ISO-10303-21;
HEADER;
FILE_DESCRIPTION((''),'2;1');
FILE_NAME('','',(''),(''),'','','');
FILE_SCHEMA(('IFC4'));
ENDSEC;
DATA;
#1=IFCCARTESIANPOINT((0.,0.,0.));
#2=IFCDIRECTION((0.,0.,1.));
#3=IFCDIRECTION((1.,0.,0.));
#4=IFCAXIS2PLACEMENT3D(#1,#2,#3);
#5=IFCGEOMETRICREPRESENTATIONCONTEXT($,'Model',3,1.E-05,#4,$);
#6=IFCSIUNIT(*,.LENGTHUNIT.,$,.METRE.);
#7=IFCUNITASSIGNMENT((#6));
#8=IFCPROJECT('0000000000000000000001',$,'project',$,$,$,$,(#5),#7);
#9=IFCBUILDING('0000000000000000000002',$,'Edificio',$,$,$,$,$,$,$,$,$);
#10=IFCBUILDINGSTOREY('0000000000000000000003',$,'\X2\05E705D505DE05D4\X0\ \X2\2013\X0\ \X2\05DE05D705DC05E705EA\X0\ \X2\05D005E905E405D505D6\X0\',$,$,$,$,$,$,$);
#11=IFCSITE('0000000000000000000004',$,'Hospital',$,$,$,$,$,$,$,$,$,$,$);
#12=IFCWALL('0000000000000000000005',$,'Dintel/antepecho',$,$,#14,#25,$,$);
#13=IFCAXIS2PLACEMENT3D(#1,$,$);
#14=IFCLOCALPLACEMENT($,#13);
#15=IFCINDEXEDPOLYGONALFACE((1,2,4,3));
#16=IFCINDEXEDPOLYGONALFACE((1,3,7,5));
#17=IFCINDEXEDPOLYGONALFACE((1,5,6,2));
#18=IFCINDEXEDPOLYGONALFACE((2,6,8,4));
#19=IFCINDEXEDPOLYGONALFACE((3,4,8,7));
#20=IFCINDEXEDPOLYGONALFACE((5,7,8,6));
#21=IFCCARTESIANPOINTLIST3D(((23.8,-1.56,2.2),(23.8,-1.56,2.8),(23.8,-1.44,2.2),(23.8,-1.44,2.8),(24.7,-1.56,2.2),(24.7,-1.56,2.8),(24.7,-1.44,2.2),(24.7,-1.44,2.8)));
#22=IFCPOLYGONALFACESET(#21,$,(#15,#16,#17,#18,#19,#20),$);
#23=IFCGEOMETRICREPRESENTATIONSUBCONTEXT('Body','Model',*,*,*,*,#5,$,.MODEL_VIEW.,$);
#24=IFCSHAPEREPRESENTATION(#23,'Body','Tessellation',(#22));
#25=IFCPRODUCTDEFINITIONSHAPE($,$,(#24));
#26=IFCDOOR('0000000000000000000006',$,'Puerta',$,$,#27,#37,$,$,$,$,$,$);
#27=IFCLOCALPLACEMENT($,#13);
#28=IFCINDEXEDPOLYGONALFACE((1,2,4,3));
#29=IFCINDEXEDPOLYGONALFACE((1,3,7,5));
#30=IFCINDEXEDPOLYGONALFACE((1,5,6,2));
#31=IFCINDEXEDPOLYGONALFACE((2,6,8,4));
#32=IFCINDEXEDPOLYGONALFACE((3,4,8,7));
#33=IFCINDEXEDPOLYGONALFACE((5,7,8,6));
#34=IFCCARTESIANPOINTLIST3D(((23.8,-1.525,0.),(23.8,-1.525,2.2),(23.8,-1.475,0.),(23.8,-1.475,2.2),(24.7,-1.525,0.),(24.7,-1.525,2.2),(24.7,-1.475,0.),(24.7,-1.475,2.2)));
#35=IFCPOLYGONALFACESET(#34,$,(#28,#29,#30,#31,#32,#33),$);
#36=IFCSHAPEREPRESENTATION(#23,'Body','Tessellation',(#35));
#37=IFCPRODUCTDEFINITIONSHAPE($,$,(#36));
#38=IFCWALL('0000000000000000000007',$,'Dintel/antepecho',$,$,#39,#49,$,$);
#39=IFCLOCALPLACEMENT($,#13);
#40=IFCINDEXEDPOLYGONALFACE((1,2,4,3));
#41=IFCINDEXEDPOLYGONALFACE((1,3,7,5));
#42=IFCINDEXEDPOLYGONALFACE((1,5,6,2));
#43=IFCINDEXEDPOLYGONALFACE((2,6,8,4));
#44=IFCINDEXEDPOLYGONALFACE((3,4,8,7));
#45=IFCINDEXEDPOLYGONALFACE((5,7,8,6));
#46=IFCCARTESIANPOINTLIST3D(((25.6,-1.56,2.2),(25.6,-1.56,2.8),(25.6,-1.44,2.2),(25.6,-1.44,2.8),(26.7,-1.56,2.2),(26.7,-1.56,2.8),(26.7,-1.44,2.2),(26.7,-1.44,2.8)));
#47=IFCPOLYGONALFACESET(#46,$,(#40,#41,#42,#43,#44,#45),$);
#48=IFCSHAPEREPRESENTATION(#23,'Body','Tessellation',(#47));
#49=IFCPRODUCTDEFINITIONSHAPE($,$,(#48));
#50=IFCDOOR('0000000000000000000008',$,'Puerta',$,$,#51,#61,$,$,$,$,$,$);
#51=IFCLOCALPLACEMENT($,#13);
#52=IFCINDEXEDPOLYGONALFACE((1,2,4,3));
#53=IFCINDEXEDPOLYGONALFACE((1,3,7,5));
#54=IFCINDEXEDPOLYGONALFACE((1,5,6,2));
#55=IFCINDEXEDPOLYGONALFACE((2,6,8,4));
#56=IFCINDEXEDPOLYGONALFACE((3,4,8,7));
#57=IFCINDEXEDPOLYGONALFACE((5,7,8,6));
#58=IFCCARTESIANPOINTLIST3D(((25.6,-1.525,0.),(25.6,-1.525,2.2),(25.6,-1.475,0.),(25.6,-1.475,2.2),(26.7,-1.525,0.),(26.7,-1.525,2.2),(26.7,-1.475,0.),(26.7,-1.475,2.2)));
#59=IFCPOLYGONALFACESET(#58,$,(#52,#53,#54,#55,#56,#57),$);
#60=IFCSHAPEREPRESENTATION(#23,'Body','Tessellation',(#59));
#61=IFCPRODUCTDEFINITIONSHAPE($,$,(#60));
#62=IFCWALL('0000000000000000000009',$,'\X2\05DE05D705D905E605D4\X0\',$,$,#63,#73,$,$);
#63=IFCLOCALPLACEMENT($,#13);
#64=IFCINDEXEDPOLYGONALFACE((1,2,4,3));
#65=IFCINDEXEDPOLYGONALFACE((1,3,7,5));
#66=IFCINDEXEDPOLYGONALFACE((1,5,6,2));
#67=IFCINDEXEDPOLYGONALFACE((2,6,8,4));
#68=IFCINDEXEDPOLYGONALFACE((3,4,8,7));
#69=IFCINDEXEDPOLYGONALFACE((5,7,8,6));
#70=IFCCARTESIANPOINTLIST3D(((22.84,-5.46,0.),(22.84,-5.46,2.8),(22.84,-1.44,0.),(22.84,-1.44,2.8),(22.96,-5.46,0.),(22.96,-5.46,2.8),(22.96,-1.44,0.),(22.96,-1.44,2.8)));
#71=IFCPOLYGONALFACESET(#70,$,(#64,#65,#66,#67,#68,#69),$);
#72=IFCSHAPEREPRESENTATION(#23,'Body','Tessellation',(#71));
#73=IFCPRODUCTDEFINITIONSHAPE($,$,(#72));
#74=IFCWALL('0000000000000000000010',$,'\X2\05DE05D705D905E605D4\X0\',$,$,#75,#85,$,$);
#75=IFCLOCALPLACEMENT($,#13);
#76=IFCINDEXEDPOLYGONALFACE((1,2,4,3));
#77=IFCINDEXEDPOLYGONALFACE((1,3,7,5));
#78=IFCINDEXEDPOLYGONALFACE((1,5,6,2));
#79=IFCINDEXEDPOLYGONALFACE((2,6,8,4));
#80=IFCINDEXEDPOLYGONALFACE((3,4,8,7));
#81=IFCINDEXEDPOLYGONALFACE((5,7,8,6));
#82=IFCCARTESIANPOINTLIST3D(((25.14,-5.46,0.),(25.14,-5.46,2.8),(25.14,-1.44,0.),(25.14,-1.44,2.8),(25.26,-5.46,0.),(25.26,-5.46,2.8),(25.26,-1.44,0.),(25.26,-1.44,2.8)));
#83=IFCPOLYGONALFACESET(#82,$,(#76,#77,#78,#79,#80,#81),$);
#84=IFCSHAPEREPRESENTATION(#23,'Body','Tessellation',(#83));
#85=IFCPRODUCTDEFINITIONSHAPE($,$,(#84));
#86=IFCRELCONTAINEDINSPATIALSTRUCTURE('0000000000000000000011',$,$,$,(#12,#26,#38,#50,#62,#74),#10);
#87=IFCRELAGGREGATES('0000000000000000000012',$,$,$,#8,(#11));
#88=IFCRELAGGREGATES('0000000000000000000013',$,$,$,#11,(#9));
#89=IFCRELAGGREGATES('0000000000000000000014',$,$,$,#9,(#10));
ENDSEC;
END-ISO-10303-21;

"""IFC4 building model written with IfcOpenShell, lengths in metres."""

from ifc_helpers import new_model, si_unit, frame, origin_with_axes, context, subcontext, project, spatial, line, indexed_curve, outline, extrude, element, save


model = new_model("IFC4")

# Units and contexts
model_context = context("Model", 3, precision=1e-05, world=origin_with_axes())
body_context = subcontext(model_context, "Body", "Model", "MODEL_VIEW")
ifc_project = project(units=[si_unit("LENGTHUNIT", "METRE")], contexts=[model_context])

# Site, building, storey
site = spatial("IfcSite", under=ifc_project, Name="Hospital")
building = spatial("IfcBuilding", under=site, Name="Edificio")
storey = spatial("IfcBuildingStorey", under=building, Name="קומה – מחלקת אשפוז")

# Wall
element("IfcWall", 1, inside=storey, Name="Dintel/antepecho", context=body_context, shape_type="SweptSolid", body=[
    extrude(outline(indexed_curve([(0.0, 0.0), (0.9, 0.0), (0.9, 0.12), (0.0, 0.12)], segments=[line(1, 2, 3, 4, 1)])), frame((23.8, -1.56, 2.2), z_axis=(0.0, 0.0, 1.0), x_axis=(1.0, 0.0, 0.0)), (0.0, 0.0, 1.0), 0.6),
])

# Door
element("IfcDoor", 2, inside=storey, Name="Puerta", context=body_context, shape_type="SweptSolid", body=[
    extrude(outline(indexed_curve([(0.0, 0.0), (0.9, 0.0), (0.9, 0.05), (0.0, 0.05)], segments=[line(1, 2, 3, 4, 1)])), frame((23.8, -1.525, 0.0), z_axis=(0.0, 0.0, 1.0), x_axis=(1.0, 0.0, 0.0)), (0.0, 0.0, 1.0), 2.2),
])

# Wall
element("IfcWall", 3, inside=storey, Name="Dintel/antepecho", context=body_context, shape_type="SweptSolid", body=[
    extrude(outline(indexed_curve([(0.0, 0.0), (1.1, 0.0), (1.1, 0.12), (0.0, 0.12)], segments=[line(1, 2, 3, 4, 1)])), frame((25.6, -1.56, 2.2), z_axis=(0.0, 0.0, 1.0), x_axis=(1.0, 0.0, 0.0)), (0.0, 0.0, 1.0), 0.6),
])

# Door
element("IfcDoor", 4, inside=storey, Name="Puerta", context=body_context, shape_type="SweptSolid", body=[
    extrude(outline(indexed_curve([(0.0, 0.0), (1.1, 0.0), (1.1, 0.05), (0.0, 0.05)], segments=[line(1, 2, 3, 4, 1)])), frame((25.6, -1.525, 0.0), z_axis=(0.0, 0.0, 1.0), x_axis=(1.0, 0.0, 0.0)), (0.0, 0.0, 1.0), 2.2),
])

# Walls
element("IfcWall", 5, inside=storey, Name="מחיצה", context=body_context, shape_type="SweptSolid", body=[
    extrude(outline(indexed_curve([(0.0, 0.0), (0.12, 0.0), (0.12, 4.02), (0.0, 4.02)], segments=[line(1, 2, 3, 4, 1)])), frame((22.84, -5.46, 0.0), z_axis=(0.0, 0.0, 1.0), x_axis=(1.0, 0.0, 0.0)), (0.0, 0.0, 1.0), 2.8),
])
element("IfcWall", 6, inside=storey, Name="מחיצה", context=body_context, shape_type="SweptSolid", body=[
    extrude(outline(indexed_curve([(0.0, 0.0), (0.12, 0.0), (0.12, 4.02), (0.0, 4.02)], segments=[line(1, 2, 3, 4, 1)])), frame((25.14, -5.46, 0.0), z_axis=(0.0, 0.0, 1.0), x_axis=(1.0, 0.0, 0.0)), (0.0, 0.0, 1.0), 2.8),
])

save(model, "model.ifc")
